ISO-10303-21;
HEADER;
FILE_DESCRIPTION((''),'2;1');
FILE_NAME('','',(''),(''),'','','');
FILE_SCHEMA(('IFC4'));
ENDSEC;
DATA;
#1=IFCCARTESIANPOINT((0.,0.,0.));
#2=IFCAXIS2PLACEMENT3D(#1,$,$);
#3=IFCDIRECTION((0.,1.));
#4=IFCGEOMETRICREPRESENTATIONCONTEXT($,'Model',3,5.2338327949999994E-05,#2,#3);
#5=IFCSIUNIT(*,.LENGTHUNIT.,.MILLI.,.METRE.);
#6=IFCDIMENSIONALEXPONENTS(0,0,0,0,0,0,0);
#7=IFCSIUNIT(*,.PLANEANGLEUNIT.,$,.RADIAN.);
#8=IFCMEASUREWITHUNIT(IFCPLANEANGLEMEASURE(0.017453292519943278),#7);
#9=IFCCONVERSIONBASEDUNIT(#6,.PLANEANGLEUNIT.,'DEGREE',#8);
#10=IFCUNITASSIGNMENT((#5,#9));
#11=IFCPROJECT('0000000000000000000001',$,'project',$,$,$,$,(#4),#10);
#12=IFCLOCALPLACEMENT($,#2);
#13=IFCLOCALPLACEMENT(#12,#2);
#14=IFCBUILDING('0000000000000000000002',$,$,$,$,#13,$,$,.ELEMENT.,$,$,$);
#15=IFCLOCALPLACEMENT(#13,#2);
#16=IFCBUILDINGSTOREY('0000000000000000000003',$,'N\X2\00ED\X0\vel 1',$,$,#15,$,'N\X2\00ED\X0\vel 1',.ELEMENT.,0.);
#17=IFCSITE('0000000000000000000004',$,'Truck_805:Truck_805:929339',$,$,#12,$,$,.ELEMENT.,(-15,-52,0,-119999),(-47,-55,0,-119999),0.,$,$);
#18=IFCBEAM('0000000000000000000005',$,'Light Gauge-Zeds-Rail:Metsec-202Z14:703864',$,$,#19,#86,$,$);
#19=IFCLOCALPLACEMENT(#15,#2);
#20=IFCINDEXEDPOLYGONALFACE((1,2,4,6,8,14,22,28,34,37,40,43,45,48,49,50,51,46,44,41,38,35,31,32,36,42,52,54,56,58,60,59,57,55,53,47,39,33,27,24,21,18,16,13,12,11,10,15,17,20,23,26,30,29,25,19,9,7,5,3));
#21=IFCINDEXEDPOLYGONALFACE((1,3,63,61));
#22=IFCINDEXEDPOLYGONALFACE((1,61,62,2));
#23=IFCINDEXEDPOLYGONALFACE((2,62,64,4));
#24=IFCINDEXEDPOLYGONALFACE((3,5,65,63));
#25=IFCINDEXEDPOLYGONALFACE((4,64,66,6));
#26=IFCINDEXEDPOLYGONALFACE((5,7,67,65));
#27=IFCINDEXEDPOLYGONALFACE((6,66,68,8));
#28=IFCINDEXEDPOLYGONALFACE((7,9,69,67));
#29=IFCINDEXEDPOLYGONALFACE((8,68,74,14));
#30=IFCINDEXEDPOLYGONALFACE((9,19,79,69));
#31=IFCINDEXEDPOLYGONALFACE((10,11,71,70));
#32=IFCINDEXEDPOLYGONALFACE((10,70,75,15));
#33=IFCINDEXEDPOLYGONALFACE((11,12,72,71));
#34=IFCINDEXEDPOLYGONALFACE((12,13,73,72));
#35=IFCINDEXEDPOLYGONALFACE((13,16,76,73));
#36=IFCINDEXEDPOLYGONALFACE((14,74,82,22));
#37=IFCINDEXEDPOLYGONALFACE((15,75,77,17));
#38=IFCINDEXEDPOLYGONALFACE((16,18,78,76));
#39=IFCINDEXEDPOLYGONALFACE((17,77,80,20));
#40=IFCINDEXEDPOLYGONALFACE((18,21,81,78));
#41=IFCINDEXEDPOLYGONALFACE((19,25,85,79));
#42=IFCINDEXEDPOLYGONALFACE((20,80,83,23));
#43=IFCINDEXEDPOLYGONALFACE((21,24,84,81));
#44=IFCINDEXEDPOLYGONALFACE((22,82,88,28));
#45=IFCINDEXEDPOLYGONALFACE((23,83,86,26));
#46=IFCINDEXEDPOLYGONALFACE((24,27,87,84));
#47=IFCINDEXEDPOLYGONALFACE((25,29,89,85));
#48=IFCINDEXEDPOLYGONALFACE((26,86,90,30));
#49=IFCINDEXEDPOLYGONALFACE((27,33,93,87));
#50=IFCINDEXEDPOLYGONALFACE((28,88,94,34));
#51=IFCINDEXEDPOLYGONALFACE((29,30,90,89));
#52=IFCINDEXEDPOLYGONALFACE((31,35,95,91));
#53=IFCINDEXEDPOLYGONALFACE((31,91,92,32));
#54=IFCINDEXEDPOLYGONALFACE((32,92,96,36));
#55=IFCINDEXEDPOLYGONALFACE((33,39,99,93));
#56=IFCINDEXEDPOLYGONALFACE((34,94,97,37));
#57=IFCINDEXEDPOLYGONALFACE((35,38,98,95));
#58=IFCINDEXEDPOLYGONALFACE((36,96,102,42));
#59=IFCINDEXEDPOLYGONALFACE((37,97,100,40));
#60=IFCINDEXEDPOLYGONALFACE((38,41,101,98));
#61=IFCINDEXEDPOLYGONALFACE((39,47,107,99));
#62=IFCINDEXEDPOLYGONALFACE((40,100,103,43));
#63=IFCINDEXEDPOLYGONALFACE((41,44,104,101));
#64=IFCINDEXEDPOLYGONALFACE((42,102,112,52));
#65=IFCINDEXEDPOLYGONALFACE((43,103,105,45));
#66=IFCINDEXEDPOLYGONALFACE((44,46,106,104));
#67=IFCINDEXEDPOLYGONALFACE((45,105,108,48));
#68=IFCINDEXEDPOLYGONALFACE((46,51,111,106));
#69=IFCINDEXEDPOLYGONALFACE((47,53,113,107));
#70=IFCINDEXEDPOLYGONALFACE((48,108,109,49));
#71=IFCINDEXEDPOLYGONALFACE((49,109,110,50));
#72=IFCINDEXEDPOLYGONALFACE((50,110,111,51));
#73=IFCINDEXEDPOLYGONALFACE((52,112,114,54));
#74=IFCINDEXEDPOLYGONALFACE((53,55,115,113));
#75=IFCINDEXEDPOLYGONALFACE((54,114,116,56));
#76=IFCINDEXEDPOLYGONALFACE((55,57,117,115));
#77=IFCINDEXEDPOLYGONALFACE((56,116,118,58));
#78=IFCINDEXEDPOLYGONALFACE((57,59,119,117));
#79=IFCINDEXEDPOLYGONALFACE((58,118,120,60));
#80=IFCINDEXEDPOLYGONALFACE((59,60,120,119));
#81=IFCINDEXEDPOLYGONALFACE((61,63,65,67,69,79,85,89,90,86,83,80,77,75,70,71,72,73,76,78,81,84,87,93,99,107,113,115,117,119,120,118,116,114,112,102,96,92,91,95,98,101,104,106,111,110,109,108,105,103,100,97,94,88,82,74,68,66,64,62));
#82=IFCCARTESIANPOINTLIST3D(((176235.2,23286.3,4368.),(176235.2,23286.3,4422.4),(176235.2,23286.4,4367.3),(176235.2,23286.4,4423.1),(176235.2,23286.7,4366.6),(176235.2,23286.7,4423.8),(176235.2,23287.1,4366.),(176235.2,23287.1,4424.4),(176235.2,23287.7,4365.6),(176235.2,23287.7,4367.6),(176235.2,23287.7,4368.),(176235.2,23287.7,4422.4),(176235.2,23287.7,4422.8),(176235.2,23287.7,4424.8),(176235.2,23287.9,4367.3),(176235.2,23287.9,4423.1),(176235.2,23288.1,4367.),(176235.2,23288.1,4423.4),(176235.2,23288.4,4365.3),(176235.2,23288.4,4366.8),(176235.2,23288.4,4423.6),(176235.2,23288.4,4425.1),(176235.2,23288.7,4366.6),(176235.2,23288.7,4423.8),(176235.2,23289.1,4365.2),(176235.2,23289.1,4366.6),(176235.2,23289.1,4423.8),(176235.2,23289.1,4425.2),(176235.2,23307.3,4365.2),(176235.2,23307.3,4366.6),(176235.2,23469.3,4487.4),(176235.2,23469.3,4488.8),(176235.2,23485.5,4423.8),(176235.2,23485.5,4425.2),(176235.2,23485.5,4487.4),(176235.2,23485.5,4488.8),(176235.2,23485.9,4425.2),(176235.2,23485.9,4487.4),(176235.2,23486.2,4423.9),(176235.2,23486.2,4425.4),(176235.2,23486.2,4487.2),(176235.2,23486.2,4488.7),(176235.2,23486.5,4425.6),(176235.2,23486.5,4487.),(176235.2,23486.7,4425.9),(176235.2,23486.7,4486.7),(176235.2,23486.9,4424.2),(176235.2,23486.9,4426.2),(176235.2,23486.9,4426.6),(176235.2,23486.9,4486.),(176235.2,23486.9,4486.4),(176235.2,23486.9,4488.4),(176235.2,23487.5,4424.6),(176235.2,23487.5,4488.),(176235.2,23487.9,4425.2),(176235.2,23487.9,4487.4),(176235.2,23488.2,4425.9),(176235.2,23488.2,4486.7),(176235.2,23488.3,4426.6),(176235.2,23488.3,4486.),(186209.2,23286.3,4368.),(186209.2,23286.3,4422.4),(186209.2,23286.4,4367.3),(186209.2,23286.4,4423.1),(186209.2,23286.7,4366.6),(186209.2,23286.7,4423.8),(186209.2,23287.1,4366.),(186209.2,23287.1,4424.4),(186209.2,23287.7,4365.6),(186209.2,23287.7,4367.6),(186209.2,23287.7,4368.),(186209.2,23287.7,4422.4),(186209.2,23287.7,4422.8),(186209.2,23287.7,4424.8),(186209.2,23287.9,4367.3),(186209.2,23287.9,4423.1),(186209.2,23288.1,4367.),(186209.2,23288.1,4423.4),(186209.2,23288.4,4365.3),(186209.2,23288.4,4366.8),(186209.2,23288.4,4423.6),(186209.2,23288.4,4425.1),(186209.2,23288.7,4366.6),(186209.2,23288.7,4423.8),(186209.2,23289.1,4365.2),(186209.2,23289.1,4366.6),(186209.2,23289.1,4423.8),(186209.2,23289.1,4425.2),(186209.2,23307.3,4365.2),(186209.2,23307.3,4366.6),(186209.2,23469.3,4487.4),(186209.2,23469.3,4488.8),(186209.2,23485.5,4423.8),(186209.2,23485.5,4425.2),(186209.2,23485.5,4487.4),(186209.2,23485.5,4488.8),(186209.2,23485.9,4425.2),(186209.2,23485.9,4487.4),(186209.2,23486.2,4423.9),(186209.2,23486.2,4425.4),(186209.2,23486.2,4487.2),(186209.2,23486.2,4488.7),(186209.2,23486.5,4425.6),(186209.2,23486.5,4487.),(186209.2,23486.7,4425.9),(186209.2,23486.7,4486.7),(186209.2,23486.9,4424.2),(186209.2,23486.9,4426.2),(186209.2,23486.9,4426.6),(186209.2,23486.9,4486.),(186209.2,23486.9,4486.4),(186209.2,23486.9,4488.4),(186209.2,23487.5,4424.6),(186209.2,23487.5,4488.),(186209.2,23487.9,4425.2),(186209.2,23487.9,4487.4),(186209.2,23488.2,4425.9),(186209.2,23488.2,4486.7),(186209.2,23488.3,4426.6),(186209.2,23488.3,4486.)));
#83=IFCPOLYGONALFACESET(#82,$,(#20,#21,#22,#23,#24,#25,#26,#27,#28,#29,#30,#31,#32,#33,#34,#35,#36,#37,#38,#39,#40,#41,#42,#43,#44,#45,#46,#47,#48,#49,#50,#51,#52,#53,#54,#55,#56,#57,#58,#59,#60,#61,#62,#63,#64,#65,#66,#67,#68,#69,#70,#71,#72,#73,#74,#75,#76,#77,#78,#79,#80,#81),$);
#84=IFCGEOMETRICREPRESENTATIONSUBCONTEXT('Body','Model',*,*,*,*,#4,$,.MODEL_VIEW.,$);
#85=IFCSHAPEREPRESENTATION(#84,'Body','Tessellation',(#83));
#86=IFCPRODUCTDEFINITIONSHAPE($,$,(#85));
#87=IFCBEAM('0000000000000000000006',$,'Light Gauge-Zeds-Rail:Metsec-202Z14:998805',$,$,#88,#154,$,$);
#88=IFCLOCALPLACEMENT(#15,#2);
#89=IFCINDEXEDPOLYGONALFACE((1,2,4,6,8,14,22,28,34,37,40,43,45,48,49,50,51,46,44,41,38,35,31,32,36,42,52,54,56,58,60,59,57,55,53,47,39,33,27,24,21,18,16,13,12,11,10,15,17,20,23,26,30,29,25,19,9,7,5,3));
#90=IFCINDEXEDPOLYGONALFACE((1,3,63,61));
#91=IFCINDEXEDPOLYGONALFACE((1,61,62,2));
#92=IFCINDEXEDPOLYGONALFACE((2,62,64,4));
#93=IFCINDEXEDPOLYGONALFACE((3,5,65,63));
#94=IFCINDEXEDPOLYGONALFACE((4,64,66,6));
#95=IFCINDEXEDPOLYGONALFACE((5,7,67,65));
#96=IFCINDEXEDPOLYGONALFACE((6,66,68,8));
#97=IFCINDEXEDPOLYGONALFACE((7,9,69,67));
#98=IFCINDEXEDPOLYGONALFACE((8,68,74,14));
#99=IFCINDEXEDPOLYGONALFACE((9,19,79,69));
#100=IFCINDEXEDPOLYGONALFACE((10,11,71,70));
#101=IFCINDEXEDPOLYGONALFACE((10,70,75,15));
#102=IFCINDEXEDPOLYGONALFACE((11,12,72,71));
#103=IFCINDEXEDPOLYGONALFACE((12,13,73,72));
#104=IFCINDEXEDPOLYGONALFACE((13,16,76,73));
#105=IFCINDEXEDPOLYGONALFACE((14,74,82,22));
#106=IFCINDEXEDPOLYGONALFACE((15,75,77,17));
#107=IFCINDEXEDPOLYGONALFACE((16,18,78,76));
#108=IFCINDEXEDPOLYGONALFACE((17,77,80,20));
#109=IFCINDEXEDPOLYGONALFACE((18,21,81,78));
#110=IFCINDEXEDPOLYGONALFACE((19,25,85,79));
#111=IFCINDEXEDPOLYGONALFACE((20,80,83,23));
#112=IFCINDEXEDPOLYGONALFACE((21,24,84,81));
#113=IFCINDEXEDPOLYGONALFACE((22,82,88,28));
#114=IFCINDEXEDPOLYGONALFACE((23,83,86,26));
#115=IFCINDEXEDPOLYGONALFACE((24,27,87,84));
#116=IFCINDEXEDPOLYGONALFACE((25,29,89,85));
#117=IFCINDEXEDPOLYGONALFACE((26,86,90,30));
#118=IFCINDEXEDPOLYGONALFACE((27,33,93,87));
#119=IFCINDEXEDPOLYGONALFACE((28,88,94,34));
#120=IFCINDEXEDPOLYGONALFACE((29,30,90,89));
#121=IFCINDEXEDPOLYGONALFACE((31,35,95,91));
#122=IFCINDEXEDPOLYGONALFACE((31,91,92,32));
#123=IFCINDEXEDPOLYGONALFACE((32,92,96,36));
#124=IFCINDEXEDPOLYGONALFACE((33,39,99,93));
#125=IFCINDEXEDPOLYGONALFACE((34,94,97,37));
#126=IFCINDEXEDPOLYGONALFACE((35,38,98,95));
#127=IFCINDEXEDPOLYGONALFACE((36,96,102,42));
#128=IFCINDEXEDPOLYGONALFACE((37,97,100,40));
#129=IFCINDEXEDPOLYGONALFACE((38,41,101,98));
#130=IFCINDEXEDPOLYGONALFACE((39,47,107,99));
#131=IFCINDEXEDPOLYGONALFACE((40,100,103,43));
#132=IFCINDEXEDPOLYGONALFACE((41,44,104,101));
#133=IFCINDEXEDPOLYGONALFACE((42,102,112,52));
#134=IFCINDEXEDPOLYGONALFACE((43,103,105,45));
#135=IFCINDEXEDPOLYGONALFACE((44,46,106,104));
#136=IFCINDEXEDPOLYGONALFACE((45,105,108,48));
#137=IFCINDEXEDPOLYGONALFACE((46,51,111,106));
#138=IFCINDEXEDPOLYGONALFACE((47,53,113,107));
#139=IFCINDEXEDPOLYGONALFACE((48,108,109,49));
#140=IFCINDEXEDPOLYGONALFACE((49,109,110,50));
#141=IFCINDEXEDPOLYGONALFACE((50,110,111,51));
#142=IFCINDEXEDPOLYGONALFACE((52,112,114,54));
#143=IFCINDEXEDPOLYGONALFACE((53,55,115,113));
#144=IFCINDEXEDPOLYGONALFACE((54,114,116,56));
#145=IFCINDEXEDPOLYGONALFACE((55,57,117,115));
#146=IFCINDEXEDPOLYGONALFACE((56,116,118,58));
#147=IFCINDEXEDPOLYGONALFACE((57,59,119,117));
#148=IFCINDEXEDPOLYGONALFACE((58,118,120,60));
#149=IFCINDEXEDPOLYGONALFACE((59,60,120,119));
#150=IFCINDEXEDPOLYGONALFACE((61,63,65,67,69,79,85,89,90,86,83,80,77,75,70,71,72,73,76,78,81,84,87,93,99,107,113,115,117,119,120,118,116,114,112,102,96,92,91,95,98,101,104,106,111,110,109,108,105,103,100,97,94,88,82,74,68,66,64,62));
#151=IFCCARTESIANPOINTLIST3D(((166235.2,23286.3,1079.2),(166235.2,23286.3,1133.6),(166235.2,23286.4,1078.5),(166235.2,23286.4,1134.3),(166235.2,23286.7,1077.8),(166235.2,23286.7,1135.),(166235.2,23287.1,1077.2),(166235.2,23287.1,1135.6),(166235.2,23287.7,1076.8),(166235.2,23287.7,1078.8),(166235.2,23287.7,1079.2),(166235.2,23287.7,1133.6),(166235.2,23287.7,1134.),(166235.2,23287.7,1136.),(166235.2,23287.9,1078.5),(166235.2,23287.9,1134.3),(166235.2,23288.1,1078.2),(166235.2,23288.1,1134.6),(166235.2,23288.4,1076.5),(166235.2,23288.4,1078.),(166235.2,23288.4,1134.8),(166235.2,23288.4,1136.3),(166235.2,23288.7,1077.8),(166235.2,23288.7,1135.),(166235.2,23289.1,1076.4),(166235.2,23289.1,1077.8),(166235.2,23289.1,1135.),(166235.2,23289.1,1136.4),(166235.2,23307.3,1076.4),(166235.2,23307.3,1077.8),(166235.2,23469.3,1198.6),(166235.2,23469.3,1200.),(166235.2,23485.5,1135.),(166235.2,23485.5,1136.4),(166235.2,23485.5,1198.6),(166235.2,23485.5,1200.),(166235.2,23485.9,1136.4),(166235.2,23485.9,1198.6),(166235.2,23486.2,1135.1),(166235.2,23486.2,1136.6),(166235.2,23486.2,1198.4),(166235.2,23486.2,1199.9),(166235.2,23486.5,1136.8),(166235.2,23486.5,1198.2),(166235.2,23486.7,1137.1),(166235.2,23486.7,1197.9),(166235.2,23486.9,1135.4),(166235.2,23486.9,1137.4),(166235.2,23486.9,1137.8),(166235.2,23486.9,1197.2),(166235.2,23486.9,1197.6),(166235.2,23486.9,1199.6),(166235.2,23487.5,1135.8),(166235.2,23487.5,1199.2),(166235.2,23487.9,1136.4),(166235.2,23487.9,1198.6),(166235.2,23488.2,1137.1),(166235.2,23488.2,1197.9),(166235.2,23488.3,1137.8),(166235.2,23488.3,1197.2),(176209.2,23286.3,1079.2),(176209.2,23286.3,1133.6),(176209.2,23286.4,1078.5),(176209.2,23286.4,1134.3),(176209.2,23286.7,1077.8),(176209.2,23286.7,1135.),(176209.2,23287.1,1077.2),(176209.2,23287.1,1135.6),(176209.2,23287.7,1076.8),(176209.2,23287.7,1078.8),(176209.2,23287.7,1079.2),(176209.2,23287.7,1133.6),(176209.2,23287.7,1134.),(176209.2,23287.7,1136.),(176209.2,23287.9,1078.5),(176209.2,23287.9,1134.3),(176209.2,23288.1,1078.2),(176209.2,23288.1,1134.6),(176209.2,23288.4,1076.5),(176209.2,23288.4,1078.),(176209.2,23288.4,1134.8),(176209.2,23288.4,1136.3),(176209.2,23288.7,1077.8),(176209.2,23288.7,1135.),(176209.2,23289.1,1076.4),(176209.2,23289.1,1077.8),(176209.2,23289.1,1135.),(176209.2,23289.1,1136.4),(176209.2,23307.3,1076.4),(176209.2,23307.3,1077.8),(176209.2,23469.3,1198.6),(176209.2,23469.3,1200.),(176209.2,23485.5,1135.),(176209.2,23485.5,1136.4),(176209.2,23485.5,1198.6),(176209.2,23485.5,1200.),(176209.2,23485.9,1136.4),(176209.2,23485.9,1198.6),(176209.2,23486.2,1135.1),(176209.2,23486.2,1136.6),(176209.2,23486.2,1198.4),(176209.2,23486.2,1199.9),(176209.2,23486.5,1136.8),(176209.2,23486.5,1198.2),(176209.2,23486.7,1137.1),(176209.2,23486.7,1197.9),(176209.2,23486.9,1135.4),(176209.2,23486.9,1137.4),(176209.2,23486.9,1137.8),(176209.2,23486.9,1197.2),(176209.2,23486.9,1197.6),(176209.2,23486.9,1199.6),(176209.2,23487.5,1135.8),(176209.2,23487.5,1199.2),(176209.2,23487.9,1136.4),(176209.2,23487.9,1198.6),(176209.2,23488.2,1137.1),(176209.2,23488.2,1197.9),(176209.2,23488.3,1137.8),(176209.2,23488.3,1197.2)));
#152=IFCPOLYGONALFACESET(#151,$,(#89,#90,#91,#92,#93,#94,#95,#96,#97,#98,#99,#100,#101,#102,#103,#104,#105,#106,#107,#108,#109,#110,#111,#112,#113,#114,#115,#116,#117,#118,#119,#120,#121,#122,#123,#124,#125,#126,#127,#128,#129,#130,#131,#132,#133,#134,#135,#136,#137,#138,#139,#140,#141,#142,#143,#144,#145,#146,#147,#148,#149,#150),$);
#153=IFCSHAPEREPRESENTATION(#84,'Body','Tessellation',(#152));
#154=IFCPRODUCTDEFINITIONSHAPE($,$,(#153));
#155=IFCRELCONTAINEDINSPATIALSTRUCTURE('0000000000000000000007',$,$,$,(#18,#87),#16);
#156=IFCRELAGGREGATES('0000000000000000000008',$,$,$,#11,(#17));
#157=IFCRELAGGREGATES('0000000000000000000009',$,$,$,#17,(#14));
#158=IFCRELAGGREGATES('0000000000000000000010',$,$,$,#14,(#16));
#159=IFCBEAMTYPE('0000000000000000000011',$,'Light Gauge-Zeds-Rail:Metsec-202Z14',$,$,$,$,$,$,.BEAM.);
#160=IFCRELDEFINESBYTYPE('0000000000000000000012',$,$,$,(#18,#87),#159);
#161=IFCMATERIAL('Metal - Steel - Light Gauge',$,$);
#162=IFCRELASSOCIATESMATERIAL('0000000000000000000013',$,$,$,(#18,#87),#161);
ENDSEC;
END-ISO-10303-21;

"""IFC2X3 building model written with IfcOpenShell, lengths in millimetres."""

from ifc_helpers import new_model, entity, si_unit, converted_unit, direction, frame, frame_2d, origin, place, context, subcontext, project, spatial, polyline, circle_curve, parameter, trimmed, segment, composite_curve, outline, extrude, material, type_object, element, save


model = new_model("IFC2X3")

# Units and contexts
model_context = context("Model", 3, precision=5.2338327949999994e-05, world=origin(), true_north=direction((0.0, 1.0)))
body_context = subcontext(model_context, "Body", "Model", "MODEL_VIEW")
ifc_project = project(units=[si_unit("LENGTHUNIT", "METRE", prefix="MILLI"), converted_unit("PLANEANGLEUNIT", "DEGREE", entity("IfcPlaneAngleMeasure", 0.017453292519943278), si_unit("PLANEANGLEUNIT", "RADIAN"), dimensions=[0, 0, 0, 0, 0, 0, 0])], contexts=[model_context])

# Site, building, storey
site_placement = place(None, origin())
site = spatial("IfcSite", under=ifc_project, at=site_placement, Name="Truck_805:Truck_805:929339", CompositionType="ELEMENT", RefLatitude=(-15, -52, 0, -119999), RefLongitude=(-47, -55, 0, -119999), RefElevation=0.0)
building_placement = place(site_placement, origin())
building = spatial("IfcBuilding", under=site, at=building_placement, CompositionType="ELEMENT")
storey_placement = place(building_placement, origin())
storey = spatial("IfcBuildingStorey", under=building, at=storey_placement, Name="Nível 1", LongName="Nível 1", CompositionType="ELEMENT", Elevation=0.0)

# Beams
ifc_material_1 = material(Name="Metal - Steel - Light Gauge")
beam_type_1 = type_object("IfcBeamType", Name="Light Gauge-Zeds-Rail:Metsec-202Z14", PredefinedType="BEAM")
beam_1_placement = place(storey_placement, frame((176222.2, 23388.2, 4488.8)))
element("IfcBeam", 1, at=beam_1_placement, inside=storey, type_object=beam_type_1, material=ifc_material_1, Name="Light Gauge-Zeds-Rail:Metsec-202Z14:703864", context=body_context, shape_type="SweptSolid", body=[
    extrude(outline(composite_curve([segment(polyline([(3.6, -101.2), (58.0, -101.2)]), True, "CONTINUOUS"), segment(trimmed(circle_curve(frame_2d((58.0, -98.4), x_axis=(0.0, -1.0)), 2.8), [parameter(0.0)], [parameter(90.0)], True, "PARAMETER"), True, "CONTINUOUS"), segment(polyline([(60.8, -98.4), (60.8, -80.2)]), True, "CONTINUOUS"), segment(polyline([(60.8, -80.2), (59.4, -80.2)]), True, "CONTINUOUS"), segment(polyline([(59.4, -80.2), (59.4, -98.4)]), True, "CONTINUOUS"), segment(trimmed(circle_curve(frame_2d((58.0, -98.4), x_axis=(1.0, 0.0)), 1.4), [parameter(270.0)], [parameter(0.0)], True, "PARAMETER"), False, "CONTINUOUS"), segment(polyline([(58.0, -99.8), (3.6, -99.8)]), True, "CONTINUOUS"), segment(trimmed(circle_curve(frame_2d((3.6, -98.4), x_axis=(0.0, -1.0)), 1.4), [parameter(270.0)], [parameter(0.0)], True, "PARAMETER"), False, "CONTINUOUS"), segment(polyline([(2.2, -98.4), (2.2, 98.0)]), True, "CONTINUOUS"), segment(trimmed(circle_curve(frame_2d((-0.6, 98.0), x_axis=(1.0, 0.0)), 2.8), [parameter(0.0)], [parameter(90.0)], True, "PARAMETER"), True, "CONTINUOUS"), segment(polyline([(-0.6, 100.8), (-60.0, 100.8)]), True, "CONTINUOUS"), segment(trimmed(circle_curve(frame_2d((-60.0, 98.0), x_axis=(0.0, 1.0)), 2.8), [parameter(0.0)], [parameter(90.0)], True, "PARAMETER"), True, "CONTINUOUS"), segment(polyline([(-62.8, 98.0), (-62.8, 81.8)]), True, "CONTINUOUS"), segment(polyline([(-62.8, 81.8), (-61.4, 81.8)]), True, "CONTINUOUS"), segment(polyline([(-61.4, 81.8), (-61.4, 98.0)]), True, "CONTINUOUS"), segment(trimmed(circle_curve(frame_2d((-60.0, 98.0), x_axis=(-1.0, 0.0)), 1.4), [parameter(270.0)], [parameter(0.0)], True, "PARAMETER"), False, "CONTINUOUS"), segment(polyline([(-60.0, 99.4), (-0.6, 99.4)]), True, "CONTINUOUS"), segment(trimmed(circle_curve(frame_2d((-0.6, 98.0), x_axis=(0.0, 1.0)), 1.4), [parameter(270.0)], [parameter(0.0)], True, "PARAMETER"), False, "CONTINUOUS"), segment(polyline([(0.8, 98.0), (0.8, -98.4)]), True, "CONTINUOUS"), segment(trimmed(circle_curve(frame_2d((3.6, -98.4), x_axis=(-1.0, 0.0)), 2.8), [parameter(0.0)], [parameter(90.0)], True, "PARAMETER"), True, "CONTINUOUS")], self_intersect=False)), frame((13.0, -0.7, -62.8), z_axis=(1.0, 0.0, 0.0), x_axis=(0.0, 0.0, -1.0)), (0.0, 0.0, 1.0), 9974.0),
])
beam_2_placement = place(storey_placement, frame((166222.2, 23388.2, 1200.0)))
element("IfcBeam", 2, at=beam_2_placement, inside=storey, type_object=beam_type_1, material=ifc_material_1, Name="Light Gauge-Zeds-Rail:Metsec-202Z14:998805", context=body_context, shape_type="SweptSolid", body=[
    extrude(outline(composite_curve([segment(polyline([(3.6, -101.2), (58.0, -101.2)]), True, "CONTINUOUS"), segment(trimmed(circle_curve(frame_2d((58.0, -98.4), x_axis=(0.0, -1.0)), 2.8), [parameter(0.0)], [parameter(90.0)], True, "PARAMETER"), True, "CONTINUOUS"), segment(polyline([(60.8, -98.4), (60.8, -80.2)]), True, "CONTINUOUS"), segment(polyline([(60.8, -80.2), (59.4, -80.2)]), True, "CONTINUOUS"), segment(polyline([(59.4, -80.2), (59.4, -98.4)]), True, "CONTINUOUS"), segment(trimmed(circle_curve(frame_2d((58.0, -98.4), x_axis=(1.0, 0.0)), 1.4), [parameter(270.0)], [parameter(0.0)], True, "PARAMETER"), False, "CONTINUOUS"), segment(polyline([(58.0, -99.8), (3.6, -99.8)]), True, "CONTINUOUS"), segment(trimmed(circle_curve(frame_2d((3.6, -98.4), x_axis=(0.0, -1.0)), 1.4), [parameter(270.0)], [parameter(0.0)], True, "PARAMETER"), False, "CONTINUOUS"), segment(polyline([(2.2, -98.4), (2.2, 98.0)]), True, "CONTINUOUS"), segment(trimmed(circle_curve(frame_2d((-0.6, 98.0), x_axis=(1.0, 0.0)), 2.8), [parameter(0.0)], [parameter(90.0)], True, "PARAMETER"), True, "CONTINUOUS"), segment(polyline([(-0.6, 100.8), (-60.0, 100.8)]), True, "CONTINUOUS"), segment(trimmed(circle_curve(frame_2d((-60.0, 98.0), x_axis=(0.0, 1.0)), 2.8), [parameter(0.0)], [parameter(90.0)], True, "PARAMETER"), True, "CONTINUOUS"), segment(polyline([(-62.8, 98.0), (-62.8, 81.8)]), True, "CONTINUOUS"), segment(polyline([(-62.8, 81.8), (-61.4, 81.8)]), True, "CONTINUOUS"), segment(polyline([(-61.4, 81.8), (-61.4, 98.0)]), True, "CONTINUOUS"), segment(trimmed(circle_curve(frame_2d((-60.0, 98.0), x_axis=(-1.0, 0.0)), 1.4), [parameter(270.0)], [parameter(0.0)], True, "PARAMETER"), False, "CONTINUOUS"), segment(polyline([(-60.0, 99.4), (-0.6, 99.4)]), True, "CONTINUOUS"), segment(trimmed(circle_curve(frame_2d((-0.6, 98.0), x_axis=(0.0, 1.0)), 1.4), [parameter(270.0)], [parameter(0.0)], True, "PARAMETER"), False, "CONTINUOUS"), segment(polyline([(0.8, 98.0), (0.8, -98.4)]), True, "CONTINUOUS"), segment(trimmed(circle_curve(frame_2d((3.6, -98.4), x_axis=(-1.0, 0.0)), 2.8), [parameter(0.0)], [parameter(90.0)], True, "PARAMETER"), True, "CONTINUOUS")], self_intersect=False)), frame((13.0, -0.7, -62.8), z_axis=(1.0, 0.0, 0.0), x_axis=(0.0, 0.0, -1.0)), (0.0, 0.0, 1.0), 9974.0),
])

save(model, "model.ifc")
